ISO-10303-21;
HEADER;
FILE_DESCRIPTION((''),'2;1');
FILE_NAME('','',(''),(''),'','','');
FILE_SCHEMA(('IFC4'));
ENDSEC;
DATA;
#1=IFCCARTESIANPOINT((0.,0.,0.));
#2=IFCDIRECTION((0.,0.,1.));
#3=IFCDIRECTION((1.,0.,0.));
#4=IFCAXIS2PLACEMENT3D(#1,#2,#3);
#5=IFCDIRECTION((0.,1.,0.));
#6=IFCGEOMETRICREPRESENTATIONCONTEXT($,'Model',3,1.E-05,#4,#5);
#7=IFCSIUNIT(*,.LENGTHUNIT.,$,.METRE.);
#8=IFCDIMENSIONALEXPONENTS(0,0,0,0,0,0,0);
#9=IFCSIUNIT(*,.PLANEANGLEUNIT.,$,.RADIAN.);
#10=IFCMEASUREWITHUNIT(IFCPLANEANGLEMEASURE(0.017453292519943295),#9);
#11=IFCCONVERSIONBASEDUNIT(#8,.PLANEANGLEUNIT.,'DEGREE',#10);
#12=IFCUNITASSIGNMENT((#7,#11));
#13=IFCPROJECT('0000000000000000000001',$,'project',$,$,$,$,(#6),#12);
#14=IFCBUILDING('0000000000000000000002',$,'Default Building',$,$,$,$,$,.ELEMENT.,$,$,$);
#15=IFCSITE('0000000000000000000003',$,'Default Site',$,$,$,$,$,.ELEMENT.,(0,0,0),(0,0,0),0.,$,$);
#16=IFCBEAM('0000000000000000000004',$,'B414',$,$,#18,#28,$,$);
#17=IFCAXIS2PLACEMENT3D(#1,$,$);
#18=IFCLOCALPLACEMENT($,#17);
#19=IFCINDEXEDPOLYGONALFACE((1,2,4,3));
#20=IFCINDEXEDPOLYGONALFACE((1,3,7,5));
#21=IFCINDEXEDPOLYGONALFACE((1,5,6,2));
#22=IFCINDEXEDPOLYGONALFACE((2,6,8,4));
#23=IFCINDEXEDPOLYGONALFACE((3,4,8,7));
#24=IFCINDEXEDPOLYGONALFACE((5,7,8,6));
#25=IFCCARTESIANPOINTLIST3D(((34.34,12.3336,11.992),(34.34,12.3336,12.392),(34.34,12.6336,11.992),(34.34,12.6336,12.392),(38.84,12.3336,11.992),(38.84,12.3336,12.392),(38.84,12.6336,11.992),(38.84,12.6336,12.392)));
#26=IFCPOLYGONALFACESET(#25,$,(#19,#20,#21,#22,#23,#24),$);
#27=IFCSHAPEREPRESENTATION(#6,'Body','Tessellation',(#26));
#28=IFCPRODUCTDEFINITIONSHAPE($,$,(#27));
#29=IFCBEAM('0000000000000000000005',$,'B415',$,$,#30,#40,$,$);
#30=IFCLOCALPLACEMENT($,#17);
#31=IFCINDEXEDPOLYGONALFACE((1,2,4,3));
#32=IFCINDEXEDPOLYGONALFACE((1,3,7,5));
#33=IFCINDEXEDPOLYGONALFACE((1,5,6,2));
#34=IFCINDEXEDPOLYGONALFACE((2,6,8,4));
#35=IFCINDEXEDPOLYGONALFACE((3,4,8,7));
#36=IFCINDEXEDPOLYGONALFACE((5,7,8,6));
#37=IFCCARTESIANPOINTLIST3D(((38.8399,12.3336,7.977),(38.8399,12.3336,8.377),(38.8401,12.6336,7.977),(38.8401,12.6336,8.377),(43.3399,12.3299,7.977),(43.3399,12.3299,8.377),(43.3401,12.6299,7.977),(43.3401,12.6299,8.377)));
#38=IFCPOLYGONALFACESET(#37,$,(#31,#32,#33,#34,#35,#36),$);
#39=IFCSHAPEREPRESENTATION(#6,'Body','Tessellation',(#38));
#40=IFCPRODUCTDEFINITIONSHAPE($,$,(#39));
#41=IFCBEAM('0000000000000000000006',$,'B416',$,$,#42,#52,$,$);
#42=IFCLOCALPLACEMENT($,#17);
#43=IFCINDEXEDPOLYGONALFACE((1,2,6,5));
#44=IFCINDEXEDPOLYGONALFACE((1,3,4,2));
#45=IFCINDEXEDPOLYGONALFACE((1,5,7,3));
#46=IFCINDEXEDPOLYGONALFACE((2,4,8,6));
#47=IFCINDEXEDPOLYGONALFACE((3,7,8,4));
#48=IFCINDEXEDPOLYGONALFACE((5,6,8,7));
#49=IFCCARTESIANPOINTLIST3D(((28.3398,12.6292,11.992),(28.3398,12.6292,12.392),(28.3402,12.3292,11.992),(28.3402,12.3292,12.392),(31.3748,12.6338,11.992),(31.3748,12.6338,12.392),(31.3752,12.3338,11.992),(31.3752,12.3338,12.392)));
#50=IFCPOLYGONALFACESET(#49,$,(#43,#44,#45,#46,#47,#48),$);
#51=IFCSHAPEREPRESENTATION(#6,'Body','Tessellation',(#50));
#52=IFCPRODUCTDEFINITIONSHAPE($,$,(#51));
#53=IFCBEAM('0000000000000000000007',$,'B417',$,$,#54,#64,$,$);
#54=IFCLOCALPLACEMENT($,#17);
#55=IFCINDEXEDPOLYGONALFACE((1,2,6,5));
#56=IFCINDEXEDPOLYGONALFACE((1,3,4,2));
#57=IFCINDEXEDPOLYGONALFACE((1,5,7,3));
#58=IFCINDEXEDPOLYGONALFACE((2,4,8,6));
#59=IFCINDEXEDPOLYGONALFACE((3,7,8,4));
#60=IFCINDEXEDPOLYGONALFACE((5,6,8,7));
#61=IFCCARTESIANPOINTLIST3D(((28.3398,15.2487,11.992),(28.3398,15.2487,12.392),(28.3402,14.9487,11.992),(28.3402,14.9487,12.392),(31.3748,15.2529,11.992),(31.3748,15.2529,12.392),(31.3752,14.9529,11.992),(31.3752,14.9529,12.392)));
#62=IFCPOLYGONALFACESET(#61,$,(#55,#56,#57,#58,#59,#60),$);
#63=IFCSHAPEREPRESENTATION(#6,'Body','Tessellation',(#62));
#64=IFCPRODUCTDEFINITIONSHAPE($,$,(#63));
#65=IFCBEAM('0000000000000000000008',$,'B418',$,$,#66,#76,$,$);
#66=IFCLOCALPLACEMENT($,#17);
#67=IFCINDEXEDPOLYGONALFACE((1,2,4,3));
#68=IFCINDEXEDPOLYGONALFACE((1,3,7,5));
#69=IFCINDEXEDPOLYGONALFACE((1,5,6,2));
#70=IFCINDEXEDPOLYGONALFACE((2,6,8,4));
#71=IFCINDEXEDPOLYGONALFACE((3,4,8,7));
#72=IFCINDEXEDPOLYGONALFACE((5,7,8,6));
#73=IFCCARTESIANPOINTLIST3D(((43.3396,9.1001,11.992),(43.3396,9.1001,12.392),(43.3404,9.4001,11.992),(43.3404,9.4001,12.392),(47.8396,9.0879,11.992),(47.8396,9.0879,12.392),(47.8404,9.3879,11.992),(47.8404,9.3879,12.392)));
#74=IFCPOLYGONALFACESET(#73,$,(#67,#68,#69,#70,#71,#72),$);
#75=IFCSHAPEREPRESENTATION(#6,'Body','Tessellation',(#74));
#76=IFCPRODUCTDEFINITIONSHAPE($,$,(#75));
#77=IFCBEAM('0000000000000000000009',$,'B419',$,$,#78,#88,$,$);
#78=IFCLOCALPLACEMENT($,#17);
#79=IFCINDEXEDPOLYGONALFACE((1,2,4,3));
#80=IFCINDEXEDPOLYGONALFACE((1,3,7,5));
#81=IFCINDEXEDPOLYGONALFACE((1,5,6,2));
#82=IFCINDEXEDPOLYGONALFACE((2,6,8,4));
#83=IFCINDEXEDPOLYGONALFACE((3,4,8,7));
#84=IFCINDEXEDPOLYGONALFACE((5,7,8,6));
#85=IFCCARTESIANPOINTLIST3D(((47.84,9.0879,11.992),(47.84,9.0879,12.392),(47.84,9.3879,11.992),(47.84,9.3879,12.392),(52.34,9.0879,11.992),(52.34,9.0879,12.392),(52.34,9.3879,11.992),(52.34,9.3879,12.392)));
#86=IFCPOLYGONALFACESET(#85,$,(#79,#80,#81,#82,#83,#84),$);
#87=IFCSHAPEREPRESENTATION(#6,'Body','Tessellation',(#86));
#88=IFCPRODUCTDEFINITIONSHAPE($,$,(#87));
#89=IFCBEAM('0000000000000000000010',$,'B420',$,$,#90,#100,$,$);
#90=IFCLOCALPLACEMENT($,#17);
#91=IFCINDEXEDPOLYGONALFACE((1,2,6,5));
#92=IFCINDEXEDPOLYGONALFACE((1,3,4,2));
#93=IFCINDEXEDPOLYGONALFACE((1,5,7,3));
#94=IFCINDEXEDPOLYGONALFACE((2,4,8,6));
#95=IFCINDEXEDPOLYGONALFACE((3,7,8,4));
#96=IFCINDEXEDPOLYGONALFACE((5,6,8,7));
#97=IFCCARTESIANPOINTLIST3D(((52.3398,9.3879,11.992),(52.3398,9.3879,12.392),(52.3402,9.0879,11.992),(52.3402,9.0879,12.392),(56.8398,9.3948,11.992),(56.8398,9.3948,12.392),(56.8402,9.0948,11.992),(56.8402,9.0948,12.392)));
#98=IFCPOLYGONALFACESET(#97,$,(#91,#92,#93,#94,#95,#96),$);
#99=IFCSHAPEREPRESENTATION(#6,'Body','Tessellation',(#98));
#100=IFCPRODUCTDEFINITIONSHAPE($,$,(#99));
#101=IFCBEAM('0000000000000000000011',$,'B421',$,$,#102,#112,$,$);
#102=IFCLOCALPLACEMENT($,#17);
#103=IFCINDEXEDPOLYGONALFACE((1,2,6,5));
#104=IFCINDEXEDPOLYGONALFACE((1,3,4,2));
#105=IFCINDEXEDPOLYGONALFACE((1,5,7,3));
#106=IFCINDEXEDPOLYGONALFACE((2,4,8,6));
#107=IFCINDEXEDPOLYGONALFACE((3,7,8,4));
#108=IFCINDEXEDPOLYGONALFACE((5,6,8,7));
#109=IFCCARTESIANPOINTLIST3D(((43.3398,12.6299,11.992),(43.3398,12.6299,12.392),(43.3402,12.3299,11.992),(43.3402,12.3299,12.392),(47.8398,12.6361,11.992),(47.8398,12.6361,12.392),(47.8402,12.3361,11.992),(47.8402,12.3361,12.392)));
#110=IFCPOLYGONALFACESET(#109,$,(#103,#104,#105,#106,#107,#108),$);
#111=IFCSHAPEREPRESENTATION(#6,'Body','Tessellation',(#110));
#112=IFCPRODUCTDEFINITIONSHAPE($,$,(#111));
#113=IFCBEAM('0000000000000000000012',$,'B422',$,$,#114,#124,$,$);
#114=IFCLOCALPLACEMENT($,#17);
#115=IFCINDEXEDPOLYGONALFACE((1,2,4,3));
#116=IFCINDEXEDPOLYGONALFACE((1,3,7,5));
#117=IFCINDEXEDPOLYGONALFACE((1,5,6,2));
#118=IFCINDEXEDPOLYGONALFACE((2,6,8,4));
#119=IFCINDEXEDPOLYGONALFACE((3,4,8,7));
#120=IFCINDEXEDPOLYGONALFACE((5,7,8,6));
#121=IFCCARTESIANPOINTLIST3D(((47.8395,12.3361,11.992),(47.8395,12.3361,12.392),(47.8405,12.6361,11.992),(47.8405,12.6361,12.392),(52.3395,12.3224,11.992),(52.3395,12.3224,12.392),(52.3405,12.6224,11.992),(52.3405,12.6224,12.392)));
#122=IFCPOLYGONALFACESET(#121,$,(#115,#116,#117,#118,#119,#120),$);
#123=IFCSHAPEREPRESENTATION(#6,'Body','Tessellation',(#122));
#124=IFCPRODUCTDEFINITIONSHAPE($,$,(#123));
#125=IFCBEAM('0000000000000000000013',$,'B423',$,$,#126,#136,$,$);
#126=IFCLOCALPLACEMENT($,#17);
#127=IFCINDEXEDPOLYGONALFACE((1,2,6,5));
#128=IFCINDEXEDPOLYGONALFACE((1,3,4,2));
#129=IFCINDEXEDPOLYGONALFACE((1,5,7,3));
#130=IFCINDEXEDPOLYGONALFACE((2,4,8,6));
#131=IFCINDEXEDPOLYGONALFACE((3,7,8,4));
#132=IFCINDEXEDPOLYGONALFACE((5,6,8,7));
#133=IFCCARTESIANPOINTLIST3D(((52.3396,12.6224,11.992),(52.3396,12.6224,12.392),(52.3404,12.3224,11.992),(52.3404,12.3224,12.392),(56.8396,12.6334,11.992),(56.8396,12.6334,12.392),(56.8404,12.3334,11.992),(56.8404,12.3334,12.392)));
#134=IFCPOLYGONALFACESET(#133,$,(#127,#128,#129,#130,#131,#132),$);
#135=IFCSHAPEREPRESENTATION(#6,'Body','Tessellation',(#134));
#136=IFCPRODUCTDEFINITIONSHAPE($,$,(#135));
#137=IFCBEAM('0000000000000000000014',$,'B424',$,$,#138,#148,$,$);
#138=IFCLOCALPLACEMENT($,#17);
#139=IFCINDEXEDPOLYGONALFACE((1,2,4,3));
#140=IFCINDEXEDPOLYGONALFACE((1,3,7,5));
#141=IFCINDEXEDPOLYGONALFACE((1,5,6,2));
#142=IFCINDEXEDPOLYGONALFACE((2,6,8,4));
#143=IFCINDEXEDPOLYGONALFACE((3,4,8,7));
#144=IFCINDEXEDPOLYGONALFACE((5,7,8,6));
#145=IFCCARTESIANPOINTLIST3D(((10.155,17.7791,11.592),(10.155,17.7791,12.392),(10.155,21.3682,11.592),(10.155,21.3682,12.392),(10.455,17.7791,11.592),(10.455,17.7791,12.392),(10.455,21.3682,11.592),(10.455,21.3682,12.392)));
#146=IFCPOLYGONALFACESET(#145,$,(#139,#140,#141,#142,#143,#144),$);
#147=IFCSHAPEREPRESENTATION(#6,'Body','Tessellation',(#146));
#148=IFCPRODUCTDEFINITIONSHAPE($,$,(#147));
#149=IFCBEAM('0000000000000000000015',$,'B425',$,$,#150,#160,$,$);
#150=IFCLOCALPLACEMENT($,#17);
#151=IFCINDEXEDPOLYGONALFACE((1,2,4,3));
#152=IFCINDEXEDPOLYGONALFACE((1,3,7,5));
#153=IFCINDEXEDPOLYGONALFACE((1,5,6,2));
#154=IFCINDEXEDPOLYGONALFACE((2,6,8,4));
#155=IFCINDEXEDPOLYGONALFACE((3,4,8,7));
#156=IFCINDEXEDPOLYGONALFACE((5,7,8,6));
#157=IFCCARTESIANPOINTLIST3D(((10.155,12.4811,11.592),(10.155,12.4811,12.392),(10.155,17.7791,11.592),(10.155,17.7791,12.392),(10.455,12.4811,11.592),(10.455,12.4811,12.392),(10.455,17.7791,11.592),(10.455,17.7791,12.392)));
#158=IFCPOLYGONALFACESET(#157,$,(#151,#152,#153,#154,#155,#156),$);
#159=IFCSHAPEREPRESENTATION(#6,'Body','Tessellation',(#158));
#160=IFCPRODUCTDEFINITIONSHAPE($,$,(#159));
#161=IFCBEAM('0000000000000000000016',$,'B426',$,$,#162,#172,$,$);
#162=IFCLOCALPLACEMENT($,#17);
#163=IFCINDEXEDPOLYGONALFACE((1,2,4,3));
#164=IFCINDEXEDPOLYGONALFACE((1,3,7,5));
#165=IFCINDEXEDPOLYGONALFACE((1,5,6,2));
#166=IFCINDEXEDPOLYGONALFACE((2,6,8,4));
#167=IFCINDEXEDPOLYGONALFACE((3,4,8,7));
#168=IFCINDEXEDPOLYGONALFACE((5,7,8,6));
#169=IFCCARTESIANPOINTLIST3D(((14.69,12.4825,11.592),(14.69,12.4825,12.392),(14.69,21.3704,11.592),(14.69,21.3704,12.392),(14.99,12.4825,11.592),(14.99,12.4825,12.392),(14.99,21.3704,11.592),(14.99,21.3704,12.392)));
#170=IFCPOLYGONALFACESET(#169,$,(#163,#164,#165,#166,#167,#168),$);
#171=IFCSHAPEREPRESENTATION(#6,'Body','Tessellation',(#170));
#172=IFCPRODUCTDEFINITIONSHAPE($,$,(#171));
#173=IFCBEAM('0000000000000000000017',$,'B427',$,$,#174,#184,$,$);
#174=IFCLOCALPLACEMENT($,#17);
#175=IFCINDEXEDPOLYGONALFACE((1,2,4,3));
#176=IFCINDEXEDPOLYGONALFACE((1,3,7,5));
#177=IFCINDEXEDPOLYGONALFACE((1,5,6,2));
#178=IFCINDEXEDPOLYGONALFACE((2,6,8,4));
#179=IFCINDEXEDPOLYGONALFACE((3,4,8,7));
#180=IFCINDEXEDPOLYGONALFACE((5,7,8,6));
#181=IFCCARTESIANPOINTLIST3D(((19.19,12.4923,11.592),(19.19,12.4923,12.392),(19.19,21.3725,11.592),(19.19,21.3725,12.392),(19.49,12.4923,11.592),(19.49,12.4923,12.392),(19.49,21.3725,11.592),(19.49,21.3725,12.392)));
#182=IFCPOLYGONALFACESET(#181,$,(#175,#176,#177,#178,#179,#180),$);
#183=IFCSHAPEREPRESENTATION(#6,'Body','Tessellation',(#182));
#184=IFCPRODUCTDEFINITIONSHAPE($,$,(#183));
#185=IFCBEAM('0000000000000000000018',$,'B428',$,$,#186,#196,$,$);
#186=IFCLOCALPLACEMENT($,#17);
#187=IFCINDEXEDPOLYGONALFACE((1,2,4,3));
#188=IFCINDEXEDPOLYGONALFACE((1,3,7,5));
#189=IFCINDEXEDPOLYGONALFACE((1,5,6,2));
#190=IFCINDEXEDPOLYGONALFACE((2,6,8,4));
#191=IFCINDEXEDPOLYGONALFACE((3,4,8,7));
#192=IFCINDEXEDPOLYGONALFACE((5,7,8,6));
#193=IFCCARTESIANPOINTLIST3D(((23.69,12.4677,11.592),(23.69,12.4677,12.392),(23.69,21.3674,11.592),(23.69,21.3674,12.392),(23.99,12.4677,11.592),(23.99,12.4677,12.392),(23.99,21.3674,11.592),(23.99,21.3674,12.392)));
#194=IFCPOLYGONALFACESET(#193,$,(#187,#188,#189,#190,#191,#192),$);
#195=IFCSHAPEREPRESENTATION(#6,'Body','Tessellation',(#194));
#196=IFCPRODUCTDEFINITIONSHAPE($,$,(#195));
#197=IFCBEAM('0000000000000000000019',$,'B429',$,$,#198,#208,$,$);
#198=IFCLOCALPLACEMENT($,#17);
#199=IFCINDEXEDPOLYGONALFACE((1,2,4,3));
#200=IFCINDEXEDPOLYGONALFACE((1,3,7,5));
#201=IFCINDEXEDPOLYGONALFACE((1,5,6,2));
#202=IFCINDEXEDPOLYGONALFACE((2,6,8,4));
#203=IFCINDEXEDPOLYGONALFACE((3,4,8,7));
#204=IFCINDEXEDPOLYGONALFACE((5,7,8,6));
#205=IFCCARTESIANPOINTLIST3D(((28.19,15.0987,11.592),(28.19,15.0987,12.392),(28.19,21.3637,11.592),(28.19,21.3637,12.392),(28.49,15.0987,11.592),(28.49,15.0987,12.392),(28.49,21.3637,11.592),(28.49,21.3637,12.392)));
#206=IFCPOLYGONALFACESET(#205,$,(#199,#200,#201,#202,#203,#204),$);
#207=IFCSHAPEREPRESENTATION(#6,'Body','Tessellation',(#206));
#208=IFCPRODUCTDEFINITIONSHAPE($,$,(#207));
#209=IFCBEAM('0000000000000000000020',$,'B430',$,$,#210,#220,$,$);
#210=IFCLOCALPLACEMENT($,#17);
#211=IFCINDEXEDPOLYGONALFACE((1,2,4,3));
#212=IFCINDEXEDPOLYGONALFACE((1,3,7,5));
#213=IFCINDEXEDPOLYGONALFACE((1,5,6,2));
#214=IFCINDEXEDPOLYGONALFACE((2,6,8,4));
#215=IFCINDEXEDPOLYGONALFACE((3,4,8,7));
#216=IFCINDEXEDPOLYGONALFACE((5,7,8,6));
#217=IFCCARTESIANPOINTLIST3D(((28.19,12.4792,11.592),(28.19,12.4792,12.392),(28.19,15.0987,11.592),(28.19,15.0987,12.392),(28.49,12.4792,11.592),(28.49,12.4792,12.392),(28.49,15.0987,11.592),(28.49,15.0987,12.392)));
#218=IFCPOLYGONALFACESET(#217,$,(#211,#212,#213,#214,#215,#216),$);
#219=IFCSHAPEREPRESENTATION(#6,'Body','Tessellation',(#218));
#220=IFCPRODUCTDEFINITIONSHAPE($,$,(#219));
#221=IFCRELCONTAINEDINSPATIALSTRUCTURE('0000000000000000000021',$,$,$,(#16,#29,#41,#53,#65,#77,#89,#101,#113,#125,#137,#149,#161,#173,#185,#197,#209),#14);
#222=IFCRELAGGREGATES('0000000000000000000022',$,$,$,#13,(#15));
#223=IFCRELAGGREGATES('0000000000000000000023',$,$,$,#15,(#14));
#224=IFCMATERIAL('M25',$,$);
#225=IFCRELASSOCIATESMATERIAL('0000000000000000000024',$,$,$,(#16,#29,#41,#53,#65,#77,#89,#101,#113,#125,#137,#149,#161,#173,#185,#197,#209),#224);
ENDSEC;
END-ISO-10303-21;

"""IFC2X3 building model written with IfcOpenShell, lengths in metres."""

from ifc_helpers import new_model, entity, si_unit, converted_unit, direction, frame, frame_2d, origin_with_axes, place, context, project, spatial, rectangle, extrude, material, element, save


model = new_model("IFC2X3")

# Units and contexts
model_context = context("Model", 3, precision=1e-05, world=origin_with_axes(), true_north=direction((0.0, 1.0, 0.0)))
ifc_project = project(units=[si_unit("LENGTHUNIT", "METRE"), converted_unit("PLANEANGLEUNIT", "DEGREE", entity("IfcPlaneAngleMeasure", 0.017453292519943295), si_unit("PLANEANGLEUNIT", "RADIAN"), dimensions=[0, 0, 0, 0, 0, 0, 0])], contexts=[model_context])

# Site, building
site = spatial("IfcSite", under=ifc_project, Name="Default Site", CompositionType="ELEMENT", RefLatitude=(0, 0, 0), RefLongitude=(0, 0, 0), RefElevation=0.0)
building = spatial("IfcBuilding", under=site, Name="Default Building", CompositionType="ELEMENT")

# Beams
ifc_material = material(Name="M25")
placement = place(None, origin_with_axes())
element("IfcBeam", 1, at=placement, inside=building, material=ifc_material, Name="B414", context=model_context, shape_type="SweptSolid", body=[
    extrude(rectangle(XDim=0.3, YDim=0.4, at=frame_2d((0.0, 0.0), x_axis=(0.0, 1.0, 0.0))), frame((34.34, 12.4836, 12.192), z_axis=(1.0, -0.000008, 0.0), x_axis=(0.0, 0.0, -1.0)), (0.0, 0.0, 1.0), 4.5),
])
element("IfcBeam", 2, at=placement, inside=building, material=ifc_material, Name="B415", context=model_context, shape_type="SweptSolid", body=[
    extrude(rectangle(XDim=0.3, YDim=0.4, at=frame_2d((0.0, 0.0), x_axis=(0.0, 1.0, 0.0))), frame((38.84, 12.4836, 8.177), z_axis=(1.0, -0.000826, 0.0), x_axis=(0.0, 0.0, -1.0)), (0.0, 0.0, 1.0), 4.5),
])
element("IfcBeam", 3, at=placement, inside=building, material=ifc_material, Name="B416", context=model_context, shape_type="SweptSolid", body=[
    extrude(rectangle(XDim=0.3, YDim=0.4, at=frame_2d((0.0, 0.0), x_axis=(0.0, 1.0, 0.0))), frame((28.34, 12.4792, 12.192), z_axis=(0.999999, 0.001542, 0.0), x_axis=(0.0, 0.0, -1.0)), (0.0, 0.0, 1.0), 3.035),
])
element("IfcBeam", 4, at=placement, inside=building, material=ifc_material, Name="B417", context=model_context, shape_type="SweptSolid", body=[
    extrude(rectangle(XDim=0.3, YDim=0.4, at=frame_2d((0.0, 0.0), x_axis=(0.0, 1.0, 0.0))), frame((31.375, 15.1029, 12.192), z_axis=(-0.999999, -0.001391, 0.0), x_axis=(0.0, 0.0, -1.0)), (0.0, 0.0, 1.0), 3.035),
])
element("IfcBeam", 5, at=placement, inside=building, material=ifc_material, Name="B418", context=model_context, shape_type="SweptSolid", body=[
    extrude(rectangle(XDim=0.3, YDim=0.4, at=frame_2d((0.0, 0.0), x_axis=(0.0, 1.0, 0.0))), frame((43.34, 9.2501, 12.192), z_axis=(0.999996, -0.002702, 0.0), x_axis=(0.0, 0.0, -1.0)), (0.0, 0.0, 1.0), 4.5),
])
element("IfcBeam", 6, at=placement, inside=building, material=ifc_material, Name="B419", context=model_context, shape_type="SweptSolid", body=[
    extrude(rectangle(XDim=0.3, YDim=0.4, at=frame_2d((0.0, 0.0), x_axis=(0.0, 1.0, 0.0))), frame((47.84, 9.2379, 12.192), z_axis=(1.0, 0.0, 0.0), x_axis=(0.0, 0.0, -1.0)), (0.0, 0.0, 1.0), 4.5),
])
element("IfcBeam", 7, at=placement, inside=building, material=ifc_material, Name="B420", context=model_context, shape_type="SweptSolid", body=[
    extrude(rectangle(XDim=0.3, YDim=0.4, at=frame_2d((0.0, 0.0), x_axis=(0.0, 1.0, 0.0))), frame((52.34, 9.2379, 12.192), z_axis=(0.999999, 0.001537, 0.0), x_axis=(0.0, 0.0, -1.0)), (0.0, 0.0, 1.0), 4.5),
])
element("IfcBeam", 8, at=placement, inside=building, material=ifc_material, Name="B421", context=model_context, shape_type="SweptSolid", body=[
    extrude(rectangle(XDim=0.3, YDim=0.4, at=frame_2d((0.0, 0.0), x_axis=(0.0, 1.0, 0.0))), frame((43.34, 12.4799, 12.192), z_axis=(0.999999, 0.001374, 0.0), x_axis=(0.0, 0.0, -1.0)), (0.0, 0.0, 1.0), 4.5),
])
element("IfcBeam", 9, at=placement, inside=building, material=ifc_material, Name="B422", context=model_context, shape_type="SweptSolid", body=[
    extrude(rectangle(XDim=0.3, YDim=0.4, at=frame_2d((0.0, 0.0), x_axis=(0.0, 1.0, 0.0))), frame((47.84, 12.4861, 12.192), z_axis=(0.999995, -0.003045, 0.0), x_axis=(0.0, 0.0, -1.0)), (0.0, 0.0, 1.0), 4.5),
])
element("IfcBeam", 10, at=placement, inside=building, material=ifc_material, Name="B423", context=model_context, shape_type="SweptSolid", body=[
    extrude(rectangle(XDim=0.3, YDim=0.4, at=frame_2d((0.0, 0.0), x_axis=(0.0, 1.0, 0.0))), frame((52.34, 12.4724, 12.192), z_axis=(0.999997, 0.002456, 0.0), x_axis=(0.0, 0.0, -1.0)), (0.0, 0.0, 1.0), 4.5),
])
element("IfcBeam", 11, at=placement, inside=building, material=ifc_material, Name="B424", context=model_context, shape_type="SweptSolid", body=[
    extrude(rectangle(XDim=0.3, YDim=0.8, at=frame_2d((0.0, 0.0), x_axis=(0.0, 1.0, 0.0))), frame((10.305, 21.3682, 11.992), z_axis=(0.0, -1.0, 0.0), x_axis=(0.0, 0.0, -1.0)), (0.0, 0.0, 1.0), 3.5891),
])
element("IfcBeam", 12, at=placement, inside=building, material=ifc_material, Name="B425", context=model_context, shape_type="SweptSolid", body=[
    extrude(rectangle(XDim=0.3, YDim=0.8, at=frame_2d((0.0, 0.0), x_axis=(0.0, 1.0, 0.0))), frame((10.305, 17.7791, 11.992), z_axis=(0.0, -1.0, 0.0), x_axis=(0.0, 0.0, -1.0)), (0.0, 0.0, 1.0), 5.298),
])
element("IfcBeam", 13, at=placement, inside=building, material=ifc_material, Name="B426", context=model_context, shape_type="SweptSolid", body=[
    extrude(rectangle(XDim=0.3, YDim=0.8, at=frame_2d((0.0, 0.0), x_axis=(0.0, 1.0, 0.0))), frame((14.84, 21.3704, 11.992), z_axis=(0.0, -1.0, 0.0), x_axis=(0.0, 0.0, -1.0)), (0.0, 0.0, 1.0), 8.8879),
])
element("IfcBeam", 14, at=placement, inside=building, material=ifc_material, Name="B427", context=model_context, shape_type="SweptSolid", body=[
    extrude(rectangle(XDim=0.3, YDim=0.8, at=frame_2d((0.0, 0.0), x_axis=(0.0, 1.0, 0.0))), frame((19.34, 21.3725, 11.992), z_axis=(0.0, -1.0, 0.0), x_axis=(0.0, 0.0, -1.0)), (0.0, 0.0, 1.0), 8.8802),
])
element("IfcBeam", 15, at=placement, inside=building, material=ifc_material, Name="B428", context=model_context, shape_type="SweptSolid", body=[
    extrude(rectangle(XDim=0.3, YDim=0.8, at=frame_2d((0.0, 0.0), x_axis=(0.0, 1.0, 0.0))), frame((23.84, 21.3674, 11.992), z_axis=(0.0, -1.0, 0.0), x_axis=(0.0, 0.0, -1.0)), (0.0, 0.0, 1.0), 8.8997),
])
element("IfcBeam", 16, at=placement, inside=building, material=ifc_material, Name="B429", context=model_context, shape_type="SweptSolid", body=[
    extrude(rectangle(XDim=0.3, YDim=0.8, at=frame_2d((0.0, 0.0), x_axis=(0.0, 1.0, 0.0))), frame((28.34, 21.3637, 11.992), z_axis=(0.0, -1.0, 0.0), x_axis=(0.0, 0.0, -1.0)), (0.0, 0.0, 1.0), 6.265),
])
element("IfcBeam", 17, at=placement, inside=building, material=ifc_material, Name="B430", context=model_context, shape_type="SweptSolid", body=[
    extrude(rectangle(XDim=0.3, YDim=0.8, at=frame_2d((0.0, 0.0), x_axis=(0.0, 1.0, 0.0))), frame((28.34, 15.0987, 11.992), z_axis=(0.0, -1.0, 0.0), x_axis=(0.0, 0.0, -1.0)), (0.0, 0.0, 1.0), 2.6195),
])

save(model, "model.ifc")
